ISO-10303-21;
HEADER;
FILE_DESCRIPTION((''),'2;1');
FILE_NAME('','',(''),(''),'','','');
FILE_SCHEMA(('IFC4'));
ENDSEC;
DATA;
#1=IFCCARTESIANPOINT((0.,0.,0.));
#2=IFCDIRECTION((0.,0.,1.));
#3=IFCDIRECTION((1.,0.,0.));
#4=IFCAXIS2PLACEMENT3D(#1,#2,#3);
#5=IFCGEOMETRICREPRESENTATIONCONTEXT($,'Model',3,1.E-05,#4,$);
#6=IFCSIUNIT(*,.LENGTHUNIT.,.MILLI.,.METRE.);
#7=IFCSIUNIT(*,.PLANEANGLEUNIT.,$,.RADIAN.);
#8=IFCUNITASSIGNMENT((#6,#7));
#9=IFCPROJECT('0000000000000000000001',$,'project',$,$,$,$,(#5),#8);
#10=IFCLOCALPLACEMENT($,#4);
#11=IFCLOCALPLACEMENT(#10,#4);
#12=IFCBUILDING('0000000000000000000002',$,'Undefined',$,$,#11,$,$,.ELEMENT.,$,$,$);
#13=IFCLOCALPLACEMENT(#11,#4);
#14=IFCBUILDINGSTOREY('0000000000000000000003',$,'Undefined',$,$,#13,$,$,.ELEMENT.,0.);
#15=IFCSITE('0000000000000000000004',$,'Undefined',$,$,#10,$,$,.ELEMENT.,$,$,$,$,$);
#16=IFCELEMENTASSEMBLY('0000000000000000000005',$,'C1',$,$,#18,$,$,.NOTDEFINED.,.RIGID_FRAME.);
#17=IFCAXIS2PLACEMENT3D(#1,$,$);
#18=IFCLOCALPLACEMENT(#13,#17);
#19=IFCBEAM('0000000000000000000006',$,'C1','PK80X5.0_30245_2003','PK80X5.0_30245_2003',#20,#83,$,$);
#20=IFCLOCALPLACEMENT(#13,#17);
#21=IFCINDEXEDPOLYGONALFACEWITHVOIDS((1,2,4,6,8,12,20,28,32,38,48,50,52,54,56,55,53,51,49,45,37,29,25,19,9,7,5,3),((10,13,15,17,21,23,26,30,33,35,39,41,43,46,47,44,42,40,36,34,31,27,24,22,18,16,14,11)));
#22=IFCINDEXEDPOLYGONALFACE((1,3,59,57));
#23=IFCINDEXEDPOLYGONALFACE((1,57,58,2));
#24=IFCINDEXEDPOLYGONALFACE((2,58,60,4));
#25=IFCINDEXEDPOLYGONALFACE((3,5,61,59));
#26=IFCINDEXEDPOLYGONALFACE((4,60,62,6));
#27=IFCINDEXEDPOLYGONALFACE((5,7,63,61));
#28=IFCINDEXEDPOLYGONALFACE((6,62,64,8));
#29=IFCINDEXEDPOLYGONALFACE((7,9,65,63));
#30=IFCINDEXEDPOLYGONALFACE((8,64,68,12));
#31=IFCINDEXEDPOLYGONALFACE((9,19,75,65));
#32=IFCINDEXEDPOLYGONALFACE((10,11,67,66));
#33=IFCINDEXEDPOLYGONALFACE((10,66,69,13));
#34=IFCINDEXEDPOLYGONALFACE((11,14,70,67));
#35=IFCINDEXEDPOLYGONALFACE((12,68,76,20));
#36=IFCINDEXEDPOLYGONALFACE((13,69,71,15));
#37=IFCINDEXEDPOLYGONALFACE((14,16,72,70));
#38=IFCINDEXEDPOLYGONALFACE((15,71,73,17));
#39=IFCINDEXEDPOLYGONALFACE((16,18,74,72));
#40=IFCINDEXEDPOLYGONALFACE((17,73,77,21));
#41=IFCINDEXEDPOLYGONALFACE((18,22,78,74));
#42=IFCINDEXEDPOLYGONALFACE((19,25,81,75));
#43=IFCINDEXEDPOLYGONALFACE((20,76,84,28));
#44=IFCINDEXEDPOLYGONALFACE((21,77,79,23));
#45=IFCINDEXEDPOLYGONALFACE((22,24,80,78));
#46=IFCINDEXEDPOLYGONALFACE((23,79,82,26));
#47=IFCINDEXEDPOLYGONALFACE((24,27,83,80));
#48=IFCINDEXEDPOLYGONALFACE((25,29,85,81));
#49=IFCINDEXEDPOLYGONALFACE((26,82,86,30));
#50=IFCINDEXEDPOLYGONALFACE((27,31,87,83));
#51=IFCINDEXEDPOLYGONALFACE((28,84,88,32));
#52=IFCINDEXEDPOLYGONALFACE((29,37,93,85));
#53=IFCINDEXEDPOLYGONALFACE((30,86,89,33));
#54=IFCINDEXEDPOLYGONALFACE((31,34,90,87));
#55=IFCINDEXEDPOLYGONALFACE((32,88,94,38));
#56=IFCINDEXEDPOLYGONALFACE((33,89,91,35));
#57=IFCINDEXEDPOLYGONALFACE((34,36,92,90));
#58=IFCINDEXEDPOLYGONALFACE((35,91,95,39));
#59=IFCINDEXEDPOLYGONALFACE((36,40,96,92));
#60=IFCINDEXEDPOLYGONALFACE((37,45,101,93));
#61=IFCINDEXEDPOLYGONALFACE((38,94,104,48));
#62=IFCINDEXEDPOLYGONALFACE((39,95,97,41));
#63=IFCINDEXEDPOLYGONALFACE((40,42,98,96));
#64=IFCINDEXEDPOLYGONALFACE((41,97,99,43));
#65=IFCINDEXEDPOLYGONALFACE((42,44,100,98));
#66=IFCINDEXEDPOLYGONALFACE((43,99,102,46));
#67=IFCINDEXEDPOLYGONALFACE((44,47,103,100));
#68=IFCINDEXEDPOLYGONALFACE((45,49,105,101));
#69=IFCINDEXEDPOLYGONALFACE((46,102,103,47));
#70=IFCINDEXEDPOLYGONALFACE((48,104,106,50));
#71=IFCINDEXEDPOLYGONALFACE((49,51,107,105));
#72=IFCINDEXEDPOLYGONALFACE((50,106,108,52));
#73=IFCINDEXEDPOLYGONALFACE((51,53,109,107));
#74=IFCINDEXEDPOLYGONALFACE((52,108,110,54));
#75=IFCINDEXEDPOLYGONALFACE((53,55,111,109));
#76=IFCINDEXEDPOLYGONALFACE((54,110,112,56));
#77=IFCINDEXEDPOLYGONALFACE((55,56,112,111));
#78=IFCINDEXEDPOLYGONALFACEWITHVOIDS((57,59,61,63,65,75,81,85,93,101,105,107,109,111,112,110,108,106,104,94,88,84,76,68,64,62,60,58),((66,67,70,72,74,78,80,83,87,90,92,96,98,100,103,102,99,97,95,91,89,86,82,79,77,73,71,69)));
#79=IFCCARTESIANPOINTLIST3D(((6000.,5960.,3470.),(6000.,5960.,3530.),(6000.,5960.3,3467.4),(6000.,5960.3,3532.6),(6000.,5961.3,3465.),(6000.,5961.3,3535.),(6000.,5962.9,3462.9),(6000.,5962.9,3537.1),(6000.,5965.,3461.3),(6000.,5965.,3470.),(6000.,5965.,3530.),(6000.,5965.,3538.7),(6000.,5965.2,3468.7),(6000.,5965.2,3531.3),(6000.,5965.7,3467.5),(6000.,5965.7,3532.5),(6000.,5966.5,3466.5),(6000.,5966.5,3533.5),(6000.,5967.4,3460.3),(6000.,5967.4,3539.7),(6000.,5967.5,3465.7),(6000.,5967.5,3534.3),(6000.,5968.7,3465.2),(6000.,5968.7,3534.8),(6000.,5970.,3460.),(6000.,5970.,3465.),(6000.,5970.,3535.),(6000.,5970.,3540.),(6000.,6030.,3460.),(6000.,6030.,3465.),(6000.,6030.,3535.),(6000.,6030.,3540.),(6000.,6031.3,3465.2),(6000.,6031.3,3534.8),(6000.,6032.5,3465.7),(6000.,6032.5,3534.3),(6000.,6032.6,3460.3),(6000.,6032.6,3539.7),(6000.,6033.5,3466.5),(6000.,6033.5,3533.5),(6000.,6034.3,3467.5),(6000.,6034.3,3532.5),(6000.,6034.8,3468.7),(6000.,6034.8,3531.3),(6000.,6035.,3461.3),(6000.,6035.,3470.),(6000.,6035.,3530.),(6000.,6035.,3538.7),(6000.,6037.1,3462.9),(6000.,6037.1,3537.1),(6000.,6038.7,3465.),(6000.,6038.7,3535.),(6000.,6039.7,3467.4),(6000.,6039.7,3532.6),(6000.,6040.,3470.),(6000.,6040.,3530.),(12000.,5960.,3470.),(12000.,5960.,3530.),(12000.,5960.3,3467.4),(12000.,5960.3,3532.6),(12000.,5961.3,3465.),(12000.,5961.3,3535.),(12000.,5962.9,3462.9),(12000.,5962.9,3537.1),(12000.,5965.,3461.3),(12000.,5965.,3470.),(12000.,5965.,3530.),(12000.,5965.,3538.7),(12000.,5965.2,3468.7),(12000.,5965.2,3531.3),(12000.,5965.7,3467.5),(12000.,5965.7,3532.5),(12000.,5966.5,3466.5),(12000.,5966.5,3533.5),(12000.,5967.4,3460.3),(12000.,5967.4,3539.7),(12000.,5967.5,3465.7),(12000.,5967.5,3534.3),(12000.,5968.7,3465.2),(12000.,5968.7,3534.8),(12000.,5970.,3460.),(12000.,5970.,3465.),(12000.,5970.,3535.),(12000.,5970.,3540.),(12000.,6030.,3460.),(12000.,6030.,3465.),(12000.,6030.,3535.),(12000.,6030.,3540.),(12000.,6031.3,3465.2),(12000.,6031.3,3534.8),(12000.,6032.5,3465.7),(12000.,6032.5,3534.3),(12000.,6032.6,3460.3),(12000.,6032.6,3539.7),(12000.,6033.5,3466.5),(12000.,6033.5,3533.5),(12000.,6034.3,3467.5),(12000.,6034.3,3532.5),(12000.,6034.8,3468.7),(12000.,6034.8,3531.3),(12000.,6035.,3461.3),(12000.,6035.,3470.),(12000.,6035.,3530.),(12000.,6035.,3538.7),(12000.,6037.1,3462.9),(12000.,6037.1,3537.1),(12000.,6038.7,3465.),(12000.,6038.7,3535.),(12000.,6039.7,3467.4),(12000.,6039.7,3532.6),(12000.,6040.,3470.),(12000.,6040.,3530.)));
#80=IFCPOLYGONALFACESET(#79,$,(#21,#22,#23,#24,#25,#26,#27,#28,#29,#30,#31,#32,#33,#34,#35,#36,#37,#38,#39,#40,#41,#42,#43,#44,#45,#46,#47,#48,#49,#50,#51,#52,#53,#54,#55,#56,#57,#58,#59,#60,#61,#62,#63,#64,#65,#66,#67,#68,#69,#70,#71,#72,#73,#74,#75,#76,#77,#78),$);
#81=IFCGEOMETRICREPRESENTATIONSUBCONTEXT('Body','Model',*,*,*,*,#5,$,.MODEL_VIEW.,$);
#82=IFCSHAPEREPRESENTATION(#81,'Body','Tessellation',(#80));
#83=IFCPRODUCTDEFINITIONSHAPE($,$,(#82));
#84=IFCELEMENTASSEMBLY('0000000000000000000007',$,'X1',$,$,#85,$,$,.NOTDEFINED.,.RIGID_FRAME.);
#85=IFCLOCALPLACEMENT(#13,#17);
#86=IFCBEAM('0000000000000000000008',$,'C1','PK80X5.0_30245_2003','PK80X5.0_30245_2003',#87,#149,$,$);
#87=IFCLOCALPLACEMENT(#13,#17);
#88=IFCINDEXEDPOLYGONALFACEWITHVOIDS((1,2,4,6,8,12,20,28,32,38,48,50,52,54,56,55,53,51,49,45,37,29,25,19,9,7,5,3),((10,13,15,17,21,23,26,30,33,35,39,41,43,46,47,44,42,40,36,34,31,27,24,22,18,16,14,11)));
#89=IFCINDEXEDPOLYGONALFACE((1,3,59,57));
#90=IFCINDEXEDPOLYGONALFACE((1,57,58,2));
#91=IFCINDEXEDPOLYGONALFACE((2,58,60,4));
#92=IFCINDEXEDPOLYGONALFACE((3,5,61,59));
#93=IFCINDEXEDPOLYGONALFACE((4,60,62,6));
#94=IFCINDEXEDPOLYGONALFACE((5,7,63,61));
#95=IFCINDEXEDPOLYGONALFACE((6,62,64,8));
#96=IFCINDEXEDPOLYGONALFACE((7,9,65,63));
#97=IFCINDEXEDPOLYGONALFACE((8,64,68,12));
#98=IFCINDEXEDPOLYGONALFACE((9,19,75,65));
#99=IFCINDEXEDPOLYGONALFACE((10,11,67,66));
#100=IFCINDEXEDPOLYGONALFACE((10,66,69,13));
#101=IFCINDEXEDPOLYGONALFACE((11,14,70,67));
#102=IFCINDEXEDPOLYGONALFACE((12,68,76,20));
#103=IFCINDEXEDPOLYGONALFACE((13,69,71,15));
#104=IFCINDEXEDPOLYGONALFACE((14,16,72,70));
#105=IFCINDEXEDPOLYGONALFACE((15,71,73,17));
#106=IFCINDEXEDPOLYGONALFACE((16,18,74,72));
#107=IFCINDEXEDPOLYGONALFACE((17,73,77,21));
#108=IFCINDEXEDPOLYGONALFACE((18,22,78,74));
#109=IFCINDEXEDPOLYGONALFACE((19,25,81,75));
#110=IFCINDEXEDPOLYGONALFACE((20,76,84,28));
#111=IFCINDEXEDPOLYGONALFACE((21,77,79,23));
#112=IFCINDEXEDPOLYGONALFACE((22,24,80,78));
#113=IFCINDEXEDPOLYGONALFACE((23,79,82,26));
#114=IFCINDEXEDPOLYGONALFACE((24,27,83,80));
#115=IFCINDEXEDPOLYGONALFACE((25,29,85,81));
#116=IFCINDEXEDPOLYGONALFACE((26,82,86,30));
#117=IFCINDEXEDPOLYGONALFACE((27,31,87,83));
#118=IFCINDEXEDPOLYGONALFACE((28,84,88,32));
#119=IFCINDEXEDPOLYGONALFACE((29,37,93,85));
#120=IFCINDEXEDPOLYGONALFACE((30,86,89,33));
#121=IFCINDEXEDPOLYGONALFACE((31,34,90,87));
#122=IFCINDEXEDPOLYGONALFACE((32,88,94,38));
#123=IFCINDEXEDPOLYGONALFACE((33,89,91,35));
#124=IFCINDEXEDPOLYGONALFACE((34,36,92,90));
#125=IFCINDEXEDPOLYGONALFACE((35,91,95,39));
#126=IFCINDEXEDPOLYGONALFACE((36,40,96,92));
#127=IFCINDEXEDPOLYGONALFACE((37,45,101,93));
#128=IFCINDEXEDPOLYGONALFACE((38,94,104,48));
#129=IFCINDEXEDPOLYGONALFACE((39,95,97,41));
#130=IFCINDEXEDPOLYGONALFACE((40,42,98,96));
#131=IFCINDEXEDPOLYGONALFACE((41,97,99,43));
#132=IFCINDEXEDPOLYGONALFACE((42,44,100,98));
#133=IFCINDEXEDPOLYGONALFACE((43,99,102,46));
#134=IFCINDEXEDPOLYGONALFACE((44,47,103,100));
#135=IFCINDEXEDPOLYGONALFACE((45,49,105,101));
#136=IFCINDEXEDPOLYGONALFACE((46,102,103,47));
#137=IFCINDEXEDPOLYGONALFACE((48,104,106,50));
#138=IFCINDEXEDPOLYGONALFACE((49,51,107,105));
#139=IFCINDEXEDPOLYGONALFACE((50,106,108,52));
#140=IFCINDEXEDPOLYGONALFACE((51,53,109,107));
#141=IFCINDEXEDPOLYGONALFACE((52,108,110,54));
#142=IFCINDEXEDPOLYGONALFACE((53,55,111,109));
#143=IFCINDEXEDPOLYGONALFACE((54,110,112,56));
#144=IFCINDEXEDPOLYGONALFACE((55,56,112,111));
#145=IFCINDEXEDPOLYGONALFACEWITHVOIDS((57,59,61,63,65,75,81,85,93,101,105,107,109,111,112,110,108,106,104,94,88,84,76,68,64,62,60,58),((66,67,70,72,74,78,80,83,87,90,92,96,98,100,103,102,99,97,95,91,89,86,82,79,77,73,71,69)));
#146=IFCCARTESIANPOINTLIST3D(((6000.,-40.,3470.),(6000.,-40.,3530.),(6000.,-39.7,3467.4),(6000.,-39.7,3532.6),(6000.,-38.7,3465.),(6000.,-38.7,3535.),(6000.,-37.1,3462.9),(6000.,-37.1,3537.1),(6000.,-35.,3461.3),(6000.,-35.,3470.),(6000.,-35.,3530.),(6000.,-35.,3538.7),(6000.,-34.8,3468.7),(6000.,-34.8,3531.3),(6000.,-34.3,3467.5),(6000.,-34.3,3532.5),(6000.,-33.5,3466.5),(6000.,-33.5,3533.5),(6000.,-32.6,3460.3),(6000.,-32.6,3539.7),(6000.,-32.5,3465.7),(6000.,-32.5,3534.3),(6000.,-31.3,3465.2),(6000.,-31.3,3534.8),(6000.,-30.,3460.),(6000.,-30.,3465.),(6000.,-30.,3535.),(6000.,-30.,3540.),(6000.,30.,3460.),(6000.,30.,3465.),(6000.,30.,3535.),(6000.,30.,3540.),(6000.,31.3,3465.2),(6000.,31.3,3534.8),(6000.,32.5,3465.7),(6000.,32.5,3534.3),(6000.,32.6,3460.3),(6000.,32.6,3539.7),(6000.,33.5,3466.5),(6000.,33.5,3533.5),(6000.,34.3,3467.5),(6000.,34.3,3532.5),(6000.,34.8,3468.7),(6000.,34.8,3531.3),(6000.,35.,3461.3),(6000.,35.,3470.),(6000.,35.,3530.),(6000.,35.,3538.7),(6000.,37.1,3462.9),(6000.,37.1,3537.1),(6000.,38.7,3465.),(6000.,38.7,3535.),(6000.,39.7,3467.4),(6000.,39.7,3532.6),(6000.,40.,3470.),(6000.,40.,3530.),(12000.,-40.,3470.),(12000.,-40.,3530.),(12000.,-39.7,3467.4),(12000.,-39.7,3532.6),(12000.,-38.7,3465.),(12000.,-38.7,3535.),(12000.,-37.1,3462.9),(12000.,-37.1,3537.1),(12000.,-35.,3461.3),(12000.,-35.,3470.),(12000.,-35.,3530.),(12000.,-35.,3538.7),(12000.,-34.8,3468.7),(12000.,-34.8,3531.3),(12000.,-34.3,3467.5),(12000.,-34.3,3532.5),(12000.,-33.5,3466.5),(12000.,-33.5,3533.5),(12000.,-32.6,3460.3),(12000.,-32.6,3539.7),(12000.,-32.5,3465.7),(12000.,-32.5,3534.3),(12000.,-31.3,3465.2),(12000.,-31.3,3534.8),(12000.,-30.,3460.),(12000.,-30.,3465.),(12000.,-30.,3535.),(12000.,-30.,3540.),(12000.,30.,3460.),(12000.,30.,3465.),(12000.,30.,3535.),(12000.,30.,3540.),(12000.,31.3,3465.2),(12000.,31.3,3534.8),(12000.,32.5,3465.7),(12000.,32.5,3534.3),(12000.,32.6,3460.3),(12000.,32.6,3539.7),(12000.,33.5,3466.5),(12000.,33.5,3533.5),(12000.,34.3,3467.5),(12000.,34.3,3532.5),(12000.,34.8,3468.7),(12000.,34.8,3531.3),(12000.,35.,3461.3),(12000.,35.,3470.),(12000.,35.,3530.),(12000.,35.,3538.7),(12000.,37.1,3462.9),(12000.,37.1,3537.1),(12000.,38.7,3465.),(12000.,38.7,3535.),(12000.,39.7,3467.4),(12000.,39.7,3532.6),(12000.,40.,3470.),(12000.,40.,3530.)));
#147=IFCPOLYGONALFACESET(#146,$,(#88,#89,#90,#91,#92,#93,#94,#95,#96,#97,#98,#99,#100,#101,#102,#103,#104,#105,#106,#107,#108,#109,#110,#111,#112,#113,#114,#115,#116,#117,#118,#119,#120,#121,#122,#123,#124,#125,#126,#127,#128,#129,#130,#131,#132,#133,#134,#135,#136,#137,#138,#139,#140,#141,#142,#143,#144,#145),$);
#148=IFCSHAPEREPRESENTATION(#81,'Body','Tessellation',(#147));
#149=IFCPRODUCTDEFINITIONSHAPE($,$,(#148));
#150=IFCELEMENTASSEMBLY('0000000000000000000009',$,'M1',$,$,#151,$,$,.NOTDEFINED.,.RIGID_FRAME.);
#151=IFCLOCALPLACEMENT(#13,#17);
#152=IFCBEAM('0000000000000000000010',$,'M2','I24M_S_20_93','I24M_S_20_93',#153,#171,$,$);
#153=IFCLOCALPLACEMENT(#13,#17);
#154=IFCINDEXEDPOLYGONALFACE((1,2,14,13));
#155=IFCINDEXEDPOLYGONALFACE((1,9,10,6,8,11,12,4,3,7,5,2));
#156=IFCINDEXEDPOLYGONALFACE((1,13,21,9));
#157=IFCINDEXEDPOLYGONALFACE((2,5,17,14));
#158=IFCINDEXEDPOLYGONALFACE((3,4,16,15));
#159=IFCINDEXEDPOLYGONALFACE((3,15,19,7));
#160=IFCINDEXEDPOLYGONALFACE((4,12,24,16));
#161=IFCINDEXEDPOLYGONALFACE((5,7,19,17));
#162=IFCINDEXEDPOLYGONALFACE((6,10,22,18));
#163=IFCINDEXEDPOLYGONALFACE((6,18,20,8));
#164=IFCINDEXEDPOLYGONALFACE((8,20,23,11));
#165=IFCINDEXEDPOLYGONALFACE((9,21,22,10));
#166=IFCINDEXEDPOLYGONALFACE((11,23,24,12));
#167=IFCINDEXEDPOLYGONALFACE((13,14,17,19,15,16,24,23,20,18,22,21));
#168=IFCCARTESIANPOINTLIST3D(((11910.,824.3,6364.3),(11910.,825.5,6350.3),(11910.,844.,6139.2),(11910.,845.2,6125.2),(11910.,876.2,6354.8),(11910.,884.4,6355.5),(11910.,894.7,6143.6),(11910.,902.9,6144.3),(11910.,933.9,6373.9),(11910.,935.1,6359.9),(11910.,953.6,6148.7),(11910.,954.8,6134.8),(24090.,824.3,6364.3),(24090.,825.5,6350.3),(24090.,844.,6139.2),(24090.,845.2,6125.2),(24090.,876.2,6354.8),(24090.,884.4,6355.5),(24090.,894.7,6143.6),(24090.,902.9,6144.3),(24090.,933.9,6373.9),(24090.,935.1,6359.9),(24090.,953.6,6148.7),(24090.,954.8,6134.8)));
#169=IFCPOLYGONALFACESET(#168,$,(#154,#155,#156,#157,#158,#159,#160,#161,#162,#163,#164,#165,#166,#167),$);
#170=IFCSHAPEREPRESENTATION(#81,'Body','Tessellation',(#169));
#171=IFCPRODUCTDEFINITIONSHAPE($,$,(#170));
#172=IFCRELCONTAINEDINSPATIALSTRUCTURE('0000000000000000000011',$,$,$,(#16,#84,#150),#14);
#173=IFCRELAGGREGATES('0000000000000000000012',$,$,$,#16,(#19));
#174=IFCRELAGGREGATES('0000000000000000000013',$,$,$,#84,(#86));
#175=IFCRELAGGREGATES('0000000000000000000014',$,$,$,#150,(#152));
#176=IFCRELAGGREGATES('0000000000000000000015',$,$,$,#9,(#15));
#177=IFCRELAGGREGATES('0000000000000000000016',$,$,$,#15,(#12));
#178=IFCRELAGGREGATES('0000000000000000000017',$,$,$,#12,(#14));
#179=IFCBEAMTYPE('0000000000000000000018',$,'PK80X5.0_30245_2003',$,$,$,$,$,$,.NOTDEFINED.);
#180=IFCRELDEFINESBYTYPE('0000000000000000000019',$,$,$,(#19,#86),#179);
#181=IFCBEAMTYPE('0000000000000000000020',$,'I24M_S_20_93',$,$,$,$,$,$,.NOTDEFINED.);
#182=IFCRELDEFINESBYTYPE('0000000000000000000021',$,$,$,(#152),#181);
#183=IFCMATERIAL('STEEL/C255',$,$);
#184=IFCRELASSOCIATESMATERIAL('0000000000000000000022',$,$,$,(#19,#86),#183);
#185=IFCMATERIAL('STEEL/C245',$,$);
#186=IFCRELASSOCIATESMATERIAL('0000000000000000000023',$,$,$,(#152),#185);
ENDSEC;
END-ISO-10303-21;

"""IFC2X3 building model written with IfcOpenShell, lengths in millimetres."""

from ifc_helpers import new_model, si_unit, frame, origin_with_axes, origin_2d_with_axis, place, context, subcontext, project, spatial, hollow_rectangle, i_section, extrude, material, type_object, element, aggregate, save


model = new_model("IFC2X3")

# Units and contexts
model_context = context("Model", 3, precision=1e-05, world=origin_with_axes())
body_context = subcontext(model_context, "Body", "Model", "MODEL_VIEW")
ifc_project = project(units=[si_unit("LENGTHUNIT", "METRE", prefix="MILLI"), si_unit("PLANEANGLEUNIT", "RADIAN")], contexts=[model_context])

# Site, building, storey
site_placement = place(None, origin_with_axes())
site = spatial("IfcSite", under=ifc_project, at=site_placement, Name="Undefined", CompositionType="ELEMENT")
building_placement = place(site_placement, origin_with_axes())
building = spatial("IfcBuilding", under=site, at=building_placement, Name="Undefined", CompositionType="ELEMENT")
storey_placement = place(building_placement, origin_with_axes())
storey = spatial("IfcBuildingStorey", under=building, at=storey_placement, Name="Undefined", CompositionType="ELEMENT", Elevation=0.0)

# Element assemblies, beams
ifc_material_1 = material(Name="STEEL/C255")
beam_type_1 = type_object("IfcBeamType", Name="PK80X5.0_30245_2003", PredefinedType="NOTDEFINED")
assembly_1_placement = place(storey_placement, origin_with_axes())
assembly_1 = element("IfcElementAssembly", 1, at=assembly_1_placement, inside=storey, Name="C1", AssemblyPlace="NOTDEFINED", PredefinedType="RIGID_FRAME")
beam_1_placement = place(assembly_1_placement, frame((6000.0, 6000.0, 3500.0), z_axis=(0.0, 0.0, -1.0), x_axis=(1.0, 0.0, 0.0)))
beam_1 = element("IfcBeam", 2, at=beam_1_placement, type_object=beam_type_1, material=ifc_material_1, Name="C1", Description="PK80X5.0_30245_2003", ObjectType="PK80X5.0_30245_2003", context=body_context, shape_type="SweptSolid", body=[
    extrude(hollow_rectangle(XDim=80.0, YDim=80.0, WallThickness=5.0, InnerFilletRadius=5.0, OuterFilletRadius=10.0, at=origin_2d_with_axis()), frame((6000.0, 0.0, 0.0), z_axis=(-1.0, 0.0, 0.0), x_axis=(0.0, -1.0, 0.0)), (0.0, 0.0, 1.0), 6000.0),
])
aggregate(assembly_1, [beam_1])
assembly_2_placement = place(storey_placement, origin_with_axes())
assembly_2 = element("IfcElementAssembly", 3, at=assembly_2_placement, inside=storey, Name="X1", AssemblyPlace="NOTDEFINED", PredefinedType="RIGID_FRAME")
beam_2_placement = place(assembly_2_placement, frame((6000.0, 0.0, 3500.0), z_axis=(0.0, 0.0, -1.0), x_axis=(1.0, 0.0, 0.0)))
beam_2 = element("IfcBeam", 4, at=beam_2_placement, type_object=beam_type_1, material=ifc_material_1, Name="C1", Description="PK80X5.0_30245_2003", ObjectType="PK80X5.0_30245_2003", context=body_context, shape_type="SweptSolid", body=[
    extrude(hollow_rectangle(XDim=80.0, YDim=80.0, WallThickness=5.0, InnerFilletRadius=5.0, OuterFilletRadius=10.0, at=origin_2d_with_axis()), frame((6000.0, 0.0, 0.0), z_axis=(-1.0, 0.0, 0.0), x_axis=(0.0, -1.0, 0.0)), (0.0, 0.0, 1.0), 6000.0),
])
aggregate(assembly_2, [beam_2])
assembly_3_placement = place(storey_placement, origin_with_axes())
assembly_3 = element("IfcElementAssembly", 5, at=assembly_3_placement, inside=storey, Name="M1", AssemblyPlace="NOTDEFINED", PredefinedType="RIGID_FRAME")
ifc_material_2 = material(Name="STEEL/C245")
beam_type_2 = type_object("IfcBeamType", Name="I24M_S_20_93", PredefinedType="NOTDEFINED")
beam_3_placement = place(assembly_3_placement, frame((11910.0, 889.5, 6249.5), z_axis=(0.0, -0.087156, 0.996195), x_axis=(1.0, 0.0, 0.0)))
beam_3 = element("IfcBeam", 6, at=beam_3_placement, type_object=beam_type_2, material=ifc_material_2, Name="M2", Description="I24M_S_20_93", ObjectType="I24M_S_20_93", context=body_context, shape_type="SweptSolid", body=[
    extrude(i_section(OverallWidth=110.0, OverallDepth=240.0, WebThickness=8.2, FlangeThickness=14.0, at=origin_2d_with_axis()), frame((12180.0, 0.0, 0.0), z_axis=(-1.0, 0.0, 0.0), x_axis=(0.0, -1.0, 0.0)), (0.0, 0.0, 1.0), 12180.0),
])
aggregate(assembly_3, [beam_3])

save(model, "model.ifc")
